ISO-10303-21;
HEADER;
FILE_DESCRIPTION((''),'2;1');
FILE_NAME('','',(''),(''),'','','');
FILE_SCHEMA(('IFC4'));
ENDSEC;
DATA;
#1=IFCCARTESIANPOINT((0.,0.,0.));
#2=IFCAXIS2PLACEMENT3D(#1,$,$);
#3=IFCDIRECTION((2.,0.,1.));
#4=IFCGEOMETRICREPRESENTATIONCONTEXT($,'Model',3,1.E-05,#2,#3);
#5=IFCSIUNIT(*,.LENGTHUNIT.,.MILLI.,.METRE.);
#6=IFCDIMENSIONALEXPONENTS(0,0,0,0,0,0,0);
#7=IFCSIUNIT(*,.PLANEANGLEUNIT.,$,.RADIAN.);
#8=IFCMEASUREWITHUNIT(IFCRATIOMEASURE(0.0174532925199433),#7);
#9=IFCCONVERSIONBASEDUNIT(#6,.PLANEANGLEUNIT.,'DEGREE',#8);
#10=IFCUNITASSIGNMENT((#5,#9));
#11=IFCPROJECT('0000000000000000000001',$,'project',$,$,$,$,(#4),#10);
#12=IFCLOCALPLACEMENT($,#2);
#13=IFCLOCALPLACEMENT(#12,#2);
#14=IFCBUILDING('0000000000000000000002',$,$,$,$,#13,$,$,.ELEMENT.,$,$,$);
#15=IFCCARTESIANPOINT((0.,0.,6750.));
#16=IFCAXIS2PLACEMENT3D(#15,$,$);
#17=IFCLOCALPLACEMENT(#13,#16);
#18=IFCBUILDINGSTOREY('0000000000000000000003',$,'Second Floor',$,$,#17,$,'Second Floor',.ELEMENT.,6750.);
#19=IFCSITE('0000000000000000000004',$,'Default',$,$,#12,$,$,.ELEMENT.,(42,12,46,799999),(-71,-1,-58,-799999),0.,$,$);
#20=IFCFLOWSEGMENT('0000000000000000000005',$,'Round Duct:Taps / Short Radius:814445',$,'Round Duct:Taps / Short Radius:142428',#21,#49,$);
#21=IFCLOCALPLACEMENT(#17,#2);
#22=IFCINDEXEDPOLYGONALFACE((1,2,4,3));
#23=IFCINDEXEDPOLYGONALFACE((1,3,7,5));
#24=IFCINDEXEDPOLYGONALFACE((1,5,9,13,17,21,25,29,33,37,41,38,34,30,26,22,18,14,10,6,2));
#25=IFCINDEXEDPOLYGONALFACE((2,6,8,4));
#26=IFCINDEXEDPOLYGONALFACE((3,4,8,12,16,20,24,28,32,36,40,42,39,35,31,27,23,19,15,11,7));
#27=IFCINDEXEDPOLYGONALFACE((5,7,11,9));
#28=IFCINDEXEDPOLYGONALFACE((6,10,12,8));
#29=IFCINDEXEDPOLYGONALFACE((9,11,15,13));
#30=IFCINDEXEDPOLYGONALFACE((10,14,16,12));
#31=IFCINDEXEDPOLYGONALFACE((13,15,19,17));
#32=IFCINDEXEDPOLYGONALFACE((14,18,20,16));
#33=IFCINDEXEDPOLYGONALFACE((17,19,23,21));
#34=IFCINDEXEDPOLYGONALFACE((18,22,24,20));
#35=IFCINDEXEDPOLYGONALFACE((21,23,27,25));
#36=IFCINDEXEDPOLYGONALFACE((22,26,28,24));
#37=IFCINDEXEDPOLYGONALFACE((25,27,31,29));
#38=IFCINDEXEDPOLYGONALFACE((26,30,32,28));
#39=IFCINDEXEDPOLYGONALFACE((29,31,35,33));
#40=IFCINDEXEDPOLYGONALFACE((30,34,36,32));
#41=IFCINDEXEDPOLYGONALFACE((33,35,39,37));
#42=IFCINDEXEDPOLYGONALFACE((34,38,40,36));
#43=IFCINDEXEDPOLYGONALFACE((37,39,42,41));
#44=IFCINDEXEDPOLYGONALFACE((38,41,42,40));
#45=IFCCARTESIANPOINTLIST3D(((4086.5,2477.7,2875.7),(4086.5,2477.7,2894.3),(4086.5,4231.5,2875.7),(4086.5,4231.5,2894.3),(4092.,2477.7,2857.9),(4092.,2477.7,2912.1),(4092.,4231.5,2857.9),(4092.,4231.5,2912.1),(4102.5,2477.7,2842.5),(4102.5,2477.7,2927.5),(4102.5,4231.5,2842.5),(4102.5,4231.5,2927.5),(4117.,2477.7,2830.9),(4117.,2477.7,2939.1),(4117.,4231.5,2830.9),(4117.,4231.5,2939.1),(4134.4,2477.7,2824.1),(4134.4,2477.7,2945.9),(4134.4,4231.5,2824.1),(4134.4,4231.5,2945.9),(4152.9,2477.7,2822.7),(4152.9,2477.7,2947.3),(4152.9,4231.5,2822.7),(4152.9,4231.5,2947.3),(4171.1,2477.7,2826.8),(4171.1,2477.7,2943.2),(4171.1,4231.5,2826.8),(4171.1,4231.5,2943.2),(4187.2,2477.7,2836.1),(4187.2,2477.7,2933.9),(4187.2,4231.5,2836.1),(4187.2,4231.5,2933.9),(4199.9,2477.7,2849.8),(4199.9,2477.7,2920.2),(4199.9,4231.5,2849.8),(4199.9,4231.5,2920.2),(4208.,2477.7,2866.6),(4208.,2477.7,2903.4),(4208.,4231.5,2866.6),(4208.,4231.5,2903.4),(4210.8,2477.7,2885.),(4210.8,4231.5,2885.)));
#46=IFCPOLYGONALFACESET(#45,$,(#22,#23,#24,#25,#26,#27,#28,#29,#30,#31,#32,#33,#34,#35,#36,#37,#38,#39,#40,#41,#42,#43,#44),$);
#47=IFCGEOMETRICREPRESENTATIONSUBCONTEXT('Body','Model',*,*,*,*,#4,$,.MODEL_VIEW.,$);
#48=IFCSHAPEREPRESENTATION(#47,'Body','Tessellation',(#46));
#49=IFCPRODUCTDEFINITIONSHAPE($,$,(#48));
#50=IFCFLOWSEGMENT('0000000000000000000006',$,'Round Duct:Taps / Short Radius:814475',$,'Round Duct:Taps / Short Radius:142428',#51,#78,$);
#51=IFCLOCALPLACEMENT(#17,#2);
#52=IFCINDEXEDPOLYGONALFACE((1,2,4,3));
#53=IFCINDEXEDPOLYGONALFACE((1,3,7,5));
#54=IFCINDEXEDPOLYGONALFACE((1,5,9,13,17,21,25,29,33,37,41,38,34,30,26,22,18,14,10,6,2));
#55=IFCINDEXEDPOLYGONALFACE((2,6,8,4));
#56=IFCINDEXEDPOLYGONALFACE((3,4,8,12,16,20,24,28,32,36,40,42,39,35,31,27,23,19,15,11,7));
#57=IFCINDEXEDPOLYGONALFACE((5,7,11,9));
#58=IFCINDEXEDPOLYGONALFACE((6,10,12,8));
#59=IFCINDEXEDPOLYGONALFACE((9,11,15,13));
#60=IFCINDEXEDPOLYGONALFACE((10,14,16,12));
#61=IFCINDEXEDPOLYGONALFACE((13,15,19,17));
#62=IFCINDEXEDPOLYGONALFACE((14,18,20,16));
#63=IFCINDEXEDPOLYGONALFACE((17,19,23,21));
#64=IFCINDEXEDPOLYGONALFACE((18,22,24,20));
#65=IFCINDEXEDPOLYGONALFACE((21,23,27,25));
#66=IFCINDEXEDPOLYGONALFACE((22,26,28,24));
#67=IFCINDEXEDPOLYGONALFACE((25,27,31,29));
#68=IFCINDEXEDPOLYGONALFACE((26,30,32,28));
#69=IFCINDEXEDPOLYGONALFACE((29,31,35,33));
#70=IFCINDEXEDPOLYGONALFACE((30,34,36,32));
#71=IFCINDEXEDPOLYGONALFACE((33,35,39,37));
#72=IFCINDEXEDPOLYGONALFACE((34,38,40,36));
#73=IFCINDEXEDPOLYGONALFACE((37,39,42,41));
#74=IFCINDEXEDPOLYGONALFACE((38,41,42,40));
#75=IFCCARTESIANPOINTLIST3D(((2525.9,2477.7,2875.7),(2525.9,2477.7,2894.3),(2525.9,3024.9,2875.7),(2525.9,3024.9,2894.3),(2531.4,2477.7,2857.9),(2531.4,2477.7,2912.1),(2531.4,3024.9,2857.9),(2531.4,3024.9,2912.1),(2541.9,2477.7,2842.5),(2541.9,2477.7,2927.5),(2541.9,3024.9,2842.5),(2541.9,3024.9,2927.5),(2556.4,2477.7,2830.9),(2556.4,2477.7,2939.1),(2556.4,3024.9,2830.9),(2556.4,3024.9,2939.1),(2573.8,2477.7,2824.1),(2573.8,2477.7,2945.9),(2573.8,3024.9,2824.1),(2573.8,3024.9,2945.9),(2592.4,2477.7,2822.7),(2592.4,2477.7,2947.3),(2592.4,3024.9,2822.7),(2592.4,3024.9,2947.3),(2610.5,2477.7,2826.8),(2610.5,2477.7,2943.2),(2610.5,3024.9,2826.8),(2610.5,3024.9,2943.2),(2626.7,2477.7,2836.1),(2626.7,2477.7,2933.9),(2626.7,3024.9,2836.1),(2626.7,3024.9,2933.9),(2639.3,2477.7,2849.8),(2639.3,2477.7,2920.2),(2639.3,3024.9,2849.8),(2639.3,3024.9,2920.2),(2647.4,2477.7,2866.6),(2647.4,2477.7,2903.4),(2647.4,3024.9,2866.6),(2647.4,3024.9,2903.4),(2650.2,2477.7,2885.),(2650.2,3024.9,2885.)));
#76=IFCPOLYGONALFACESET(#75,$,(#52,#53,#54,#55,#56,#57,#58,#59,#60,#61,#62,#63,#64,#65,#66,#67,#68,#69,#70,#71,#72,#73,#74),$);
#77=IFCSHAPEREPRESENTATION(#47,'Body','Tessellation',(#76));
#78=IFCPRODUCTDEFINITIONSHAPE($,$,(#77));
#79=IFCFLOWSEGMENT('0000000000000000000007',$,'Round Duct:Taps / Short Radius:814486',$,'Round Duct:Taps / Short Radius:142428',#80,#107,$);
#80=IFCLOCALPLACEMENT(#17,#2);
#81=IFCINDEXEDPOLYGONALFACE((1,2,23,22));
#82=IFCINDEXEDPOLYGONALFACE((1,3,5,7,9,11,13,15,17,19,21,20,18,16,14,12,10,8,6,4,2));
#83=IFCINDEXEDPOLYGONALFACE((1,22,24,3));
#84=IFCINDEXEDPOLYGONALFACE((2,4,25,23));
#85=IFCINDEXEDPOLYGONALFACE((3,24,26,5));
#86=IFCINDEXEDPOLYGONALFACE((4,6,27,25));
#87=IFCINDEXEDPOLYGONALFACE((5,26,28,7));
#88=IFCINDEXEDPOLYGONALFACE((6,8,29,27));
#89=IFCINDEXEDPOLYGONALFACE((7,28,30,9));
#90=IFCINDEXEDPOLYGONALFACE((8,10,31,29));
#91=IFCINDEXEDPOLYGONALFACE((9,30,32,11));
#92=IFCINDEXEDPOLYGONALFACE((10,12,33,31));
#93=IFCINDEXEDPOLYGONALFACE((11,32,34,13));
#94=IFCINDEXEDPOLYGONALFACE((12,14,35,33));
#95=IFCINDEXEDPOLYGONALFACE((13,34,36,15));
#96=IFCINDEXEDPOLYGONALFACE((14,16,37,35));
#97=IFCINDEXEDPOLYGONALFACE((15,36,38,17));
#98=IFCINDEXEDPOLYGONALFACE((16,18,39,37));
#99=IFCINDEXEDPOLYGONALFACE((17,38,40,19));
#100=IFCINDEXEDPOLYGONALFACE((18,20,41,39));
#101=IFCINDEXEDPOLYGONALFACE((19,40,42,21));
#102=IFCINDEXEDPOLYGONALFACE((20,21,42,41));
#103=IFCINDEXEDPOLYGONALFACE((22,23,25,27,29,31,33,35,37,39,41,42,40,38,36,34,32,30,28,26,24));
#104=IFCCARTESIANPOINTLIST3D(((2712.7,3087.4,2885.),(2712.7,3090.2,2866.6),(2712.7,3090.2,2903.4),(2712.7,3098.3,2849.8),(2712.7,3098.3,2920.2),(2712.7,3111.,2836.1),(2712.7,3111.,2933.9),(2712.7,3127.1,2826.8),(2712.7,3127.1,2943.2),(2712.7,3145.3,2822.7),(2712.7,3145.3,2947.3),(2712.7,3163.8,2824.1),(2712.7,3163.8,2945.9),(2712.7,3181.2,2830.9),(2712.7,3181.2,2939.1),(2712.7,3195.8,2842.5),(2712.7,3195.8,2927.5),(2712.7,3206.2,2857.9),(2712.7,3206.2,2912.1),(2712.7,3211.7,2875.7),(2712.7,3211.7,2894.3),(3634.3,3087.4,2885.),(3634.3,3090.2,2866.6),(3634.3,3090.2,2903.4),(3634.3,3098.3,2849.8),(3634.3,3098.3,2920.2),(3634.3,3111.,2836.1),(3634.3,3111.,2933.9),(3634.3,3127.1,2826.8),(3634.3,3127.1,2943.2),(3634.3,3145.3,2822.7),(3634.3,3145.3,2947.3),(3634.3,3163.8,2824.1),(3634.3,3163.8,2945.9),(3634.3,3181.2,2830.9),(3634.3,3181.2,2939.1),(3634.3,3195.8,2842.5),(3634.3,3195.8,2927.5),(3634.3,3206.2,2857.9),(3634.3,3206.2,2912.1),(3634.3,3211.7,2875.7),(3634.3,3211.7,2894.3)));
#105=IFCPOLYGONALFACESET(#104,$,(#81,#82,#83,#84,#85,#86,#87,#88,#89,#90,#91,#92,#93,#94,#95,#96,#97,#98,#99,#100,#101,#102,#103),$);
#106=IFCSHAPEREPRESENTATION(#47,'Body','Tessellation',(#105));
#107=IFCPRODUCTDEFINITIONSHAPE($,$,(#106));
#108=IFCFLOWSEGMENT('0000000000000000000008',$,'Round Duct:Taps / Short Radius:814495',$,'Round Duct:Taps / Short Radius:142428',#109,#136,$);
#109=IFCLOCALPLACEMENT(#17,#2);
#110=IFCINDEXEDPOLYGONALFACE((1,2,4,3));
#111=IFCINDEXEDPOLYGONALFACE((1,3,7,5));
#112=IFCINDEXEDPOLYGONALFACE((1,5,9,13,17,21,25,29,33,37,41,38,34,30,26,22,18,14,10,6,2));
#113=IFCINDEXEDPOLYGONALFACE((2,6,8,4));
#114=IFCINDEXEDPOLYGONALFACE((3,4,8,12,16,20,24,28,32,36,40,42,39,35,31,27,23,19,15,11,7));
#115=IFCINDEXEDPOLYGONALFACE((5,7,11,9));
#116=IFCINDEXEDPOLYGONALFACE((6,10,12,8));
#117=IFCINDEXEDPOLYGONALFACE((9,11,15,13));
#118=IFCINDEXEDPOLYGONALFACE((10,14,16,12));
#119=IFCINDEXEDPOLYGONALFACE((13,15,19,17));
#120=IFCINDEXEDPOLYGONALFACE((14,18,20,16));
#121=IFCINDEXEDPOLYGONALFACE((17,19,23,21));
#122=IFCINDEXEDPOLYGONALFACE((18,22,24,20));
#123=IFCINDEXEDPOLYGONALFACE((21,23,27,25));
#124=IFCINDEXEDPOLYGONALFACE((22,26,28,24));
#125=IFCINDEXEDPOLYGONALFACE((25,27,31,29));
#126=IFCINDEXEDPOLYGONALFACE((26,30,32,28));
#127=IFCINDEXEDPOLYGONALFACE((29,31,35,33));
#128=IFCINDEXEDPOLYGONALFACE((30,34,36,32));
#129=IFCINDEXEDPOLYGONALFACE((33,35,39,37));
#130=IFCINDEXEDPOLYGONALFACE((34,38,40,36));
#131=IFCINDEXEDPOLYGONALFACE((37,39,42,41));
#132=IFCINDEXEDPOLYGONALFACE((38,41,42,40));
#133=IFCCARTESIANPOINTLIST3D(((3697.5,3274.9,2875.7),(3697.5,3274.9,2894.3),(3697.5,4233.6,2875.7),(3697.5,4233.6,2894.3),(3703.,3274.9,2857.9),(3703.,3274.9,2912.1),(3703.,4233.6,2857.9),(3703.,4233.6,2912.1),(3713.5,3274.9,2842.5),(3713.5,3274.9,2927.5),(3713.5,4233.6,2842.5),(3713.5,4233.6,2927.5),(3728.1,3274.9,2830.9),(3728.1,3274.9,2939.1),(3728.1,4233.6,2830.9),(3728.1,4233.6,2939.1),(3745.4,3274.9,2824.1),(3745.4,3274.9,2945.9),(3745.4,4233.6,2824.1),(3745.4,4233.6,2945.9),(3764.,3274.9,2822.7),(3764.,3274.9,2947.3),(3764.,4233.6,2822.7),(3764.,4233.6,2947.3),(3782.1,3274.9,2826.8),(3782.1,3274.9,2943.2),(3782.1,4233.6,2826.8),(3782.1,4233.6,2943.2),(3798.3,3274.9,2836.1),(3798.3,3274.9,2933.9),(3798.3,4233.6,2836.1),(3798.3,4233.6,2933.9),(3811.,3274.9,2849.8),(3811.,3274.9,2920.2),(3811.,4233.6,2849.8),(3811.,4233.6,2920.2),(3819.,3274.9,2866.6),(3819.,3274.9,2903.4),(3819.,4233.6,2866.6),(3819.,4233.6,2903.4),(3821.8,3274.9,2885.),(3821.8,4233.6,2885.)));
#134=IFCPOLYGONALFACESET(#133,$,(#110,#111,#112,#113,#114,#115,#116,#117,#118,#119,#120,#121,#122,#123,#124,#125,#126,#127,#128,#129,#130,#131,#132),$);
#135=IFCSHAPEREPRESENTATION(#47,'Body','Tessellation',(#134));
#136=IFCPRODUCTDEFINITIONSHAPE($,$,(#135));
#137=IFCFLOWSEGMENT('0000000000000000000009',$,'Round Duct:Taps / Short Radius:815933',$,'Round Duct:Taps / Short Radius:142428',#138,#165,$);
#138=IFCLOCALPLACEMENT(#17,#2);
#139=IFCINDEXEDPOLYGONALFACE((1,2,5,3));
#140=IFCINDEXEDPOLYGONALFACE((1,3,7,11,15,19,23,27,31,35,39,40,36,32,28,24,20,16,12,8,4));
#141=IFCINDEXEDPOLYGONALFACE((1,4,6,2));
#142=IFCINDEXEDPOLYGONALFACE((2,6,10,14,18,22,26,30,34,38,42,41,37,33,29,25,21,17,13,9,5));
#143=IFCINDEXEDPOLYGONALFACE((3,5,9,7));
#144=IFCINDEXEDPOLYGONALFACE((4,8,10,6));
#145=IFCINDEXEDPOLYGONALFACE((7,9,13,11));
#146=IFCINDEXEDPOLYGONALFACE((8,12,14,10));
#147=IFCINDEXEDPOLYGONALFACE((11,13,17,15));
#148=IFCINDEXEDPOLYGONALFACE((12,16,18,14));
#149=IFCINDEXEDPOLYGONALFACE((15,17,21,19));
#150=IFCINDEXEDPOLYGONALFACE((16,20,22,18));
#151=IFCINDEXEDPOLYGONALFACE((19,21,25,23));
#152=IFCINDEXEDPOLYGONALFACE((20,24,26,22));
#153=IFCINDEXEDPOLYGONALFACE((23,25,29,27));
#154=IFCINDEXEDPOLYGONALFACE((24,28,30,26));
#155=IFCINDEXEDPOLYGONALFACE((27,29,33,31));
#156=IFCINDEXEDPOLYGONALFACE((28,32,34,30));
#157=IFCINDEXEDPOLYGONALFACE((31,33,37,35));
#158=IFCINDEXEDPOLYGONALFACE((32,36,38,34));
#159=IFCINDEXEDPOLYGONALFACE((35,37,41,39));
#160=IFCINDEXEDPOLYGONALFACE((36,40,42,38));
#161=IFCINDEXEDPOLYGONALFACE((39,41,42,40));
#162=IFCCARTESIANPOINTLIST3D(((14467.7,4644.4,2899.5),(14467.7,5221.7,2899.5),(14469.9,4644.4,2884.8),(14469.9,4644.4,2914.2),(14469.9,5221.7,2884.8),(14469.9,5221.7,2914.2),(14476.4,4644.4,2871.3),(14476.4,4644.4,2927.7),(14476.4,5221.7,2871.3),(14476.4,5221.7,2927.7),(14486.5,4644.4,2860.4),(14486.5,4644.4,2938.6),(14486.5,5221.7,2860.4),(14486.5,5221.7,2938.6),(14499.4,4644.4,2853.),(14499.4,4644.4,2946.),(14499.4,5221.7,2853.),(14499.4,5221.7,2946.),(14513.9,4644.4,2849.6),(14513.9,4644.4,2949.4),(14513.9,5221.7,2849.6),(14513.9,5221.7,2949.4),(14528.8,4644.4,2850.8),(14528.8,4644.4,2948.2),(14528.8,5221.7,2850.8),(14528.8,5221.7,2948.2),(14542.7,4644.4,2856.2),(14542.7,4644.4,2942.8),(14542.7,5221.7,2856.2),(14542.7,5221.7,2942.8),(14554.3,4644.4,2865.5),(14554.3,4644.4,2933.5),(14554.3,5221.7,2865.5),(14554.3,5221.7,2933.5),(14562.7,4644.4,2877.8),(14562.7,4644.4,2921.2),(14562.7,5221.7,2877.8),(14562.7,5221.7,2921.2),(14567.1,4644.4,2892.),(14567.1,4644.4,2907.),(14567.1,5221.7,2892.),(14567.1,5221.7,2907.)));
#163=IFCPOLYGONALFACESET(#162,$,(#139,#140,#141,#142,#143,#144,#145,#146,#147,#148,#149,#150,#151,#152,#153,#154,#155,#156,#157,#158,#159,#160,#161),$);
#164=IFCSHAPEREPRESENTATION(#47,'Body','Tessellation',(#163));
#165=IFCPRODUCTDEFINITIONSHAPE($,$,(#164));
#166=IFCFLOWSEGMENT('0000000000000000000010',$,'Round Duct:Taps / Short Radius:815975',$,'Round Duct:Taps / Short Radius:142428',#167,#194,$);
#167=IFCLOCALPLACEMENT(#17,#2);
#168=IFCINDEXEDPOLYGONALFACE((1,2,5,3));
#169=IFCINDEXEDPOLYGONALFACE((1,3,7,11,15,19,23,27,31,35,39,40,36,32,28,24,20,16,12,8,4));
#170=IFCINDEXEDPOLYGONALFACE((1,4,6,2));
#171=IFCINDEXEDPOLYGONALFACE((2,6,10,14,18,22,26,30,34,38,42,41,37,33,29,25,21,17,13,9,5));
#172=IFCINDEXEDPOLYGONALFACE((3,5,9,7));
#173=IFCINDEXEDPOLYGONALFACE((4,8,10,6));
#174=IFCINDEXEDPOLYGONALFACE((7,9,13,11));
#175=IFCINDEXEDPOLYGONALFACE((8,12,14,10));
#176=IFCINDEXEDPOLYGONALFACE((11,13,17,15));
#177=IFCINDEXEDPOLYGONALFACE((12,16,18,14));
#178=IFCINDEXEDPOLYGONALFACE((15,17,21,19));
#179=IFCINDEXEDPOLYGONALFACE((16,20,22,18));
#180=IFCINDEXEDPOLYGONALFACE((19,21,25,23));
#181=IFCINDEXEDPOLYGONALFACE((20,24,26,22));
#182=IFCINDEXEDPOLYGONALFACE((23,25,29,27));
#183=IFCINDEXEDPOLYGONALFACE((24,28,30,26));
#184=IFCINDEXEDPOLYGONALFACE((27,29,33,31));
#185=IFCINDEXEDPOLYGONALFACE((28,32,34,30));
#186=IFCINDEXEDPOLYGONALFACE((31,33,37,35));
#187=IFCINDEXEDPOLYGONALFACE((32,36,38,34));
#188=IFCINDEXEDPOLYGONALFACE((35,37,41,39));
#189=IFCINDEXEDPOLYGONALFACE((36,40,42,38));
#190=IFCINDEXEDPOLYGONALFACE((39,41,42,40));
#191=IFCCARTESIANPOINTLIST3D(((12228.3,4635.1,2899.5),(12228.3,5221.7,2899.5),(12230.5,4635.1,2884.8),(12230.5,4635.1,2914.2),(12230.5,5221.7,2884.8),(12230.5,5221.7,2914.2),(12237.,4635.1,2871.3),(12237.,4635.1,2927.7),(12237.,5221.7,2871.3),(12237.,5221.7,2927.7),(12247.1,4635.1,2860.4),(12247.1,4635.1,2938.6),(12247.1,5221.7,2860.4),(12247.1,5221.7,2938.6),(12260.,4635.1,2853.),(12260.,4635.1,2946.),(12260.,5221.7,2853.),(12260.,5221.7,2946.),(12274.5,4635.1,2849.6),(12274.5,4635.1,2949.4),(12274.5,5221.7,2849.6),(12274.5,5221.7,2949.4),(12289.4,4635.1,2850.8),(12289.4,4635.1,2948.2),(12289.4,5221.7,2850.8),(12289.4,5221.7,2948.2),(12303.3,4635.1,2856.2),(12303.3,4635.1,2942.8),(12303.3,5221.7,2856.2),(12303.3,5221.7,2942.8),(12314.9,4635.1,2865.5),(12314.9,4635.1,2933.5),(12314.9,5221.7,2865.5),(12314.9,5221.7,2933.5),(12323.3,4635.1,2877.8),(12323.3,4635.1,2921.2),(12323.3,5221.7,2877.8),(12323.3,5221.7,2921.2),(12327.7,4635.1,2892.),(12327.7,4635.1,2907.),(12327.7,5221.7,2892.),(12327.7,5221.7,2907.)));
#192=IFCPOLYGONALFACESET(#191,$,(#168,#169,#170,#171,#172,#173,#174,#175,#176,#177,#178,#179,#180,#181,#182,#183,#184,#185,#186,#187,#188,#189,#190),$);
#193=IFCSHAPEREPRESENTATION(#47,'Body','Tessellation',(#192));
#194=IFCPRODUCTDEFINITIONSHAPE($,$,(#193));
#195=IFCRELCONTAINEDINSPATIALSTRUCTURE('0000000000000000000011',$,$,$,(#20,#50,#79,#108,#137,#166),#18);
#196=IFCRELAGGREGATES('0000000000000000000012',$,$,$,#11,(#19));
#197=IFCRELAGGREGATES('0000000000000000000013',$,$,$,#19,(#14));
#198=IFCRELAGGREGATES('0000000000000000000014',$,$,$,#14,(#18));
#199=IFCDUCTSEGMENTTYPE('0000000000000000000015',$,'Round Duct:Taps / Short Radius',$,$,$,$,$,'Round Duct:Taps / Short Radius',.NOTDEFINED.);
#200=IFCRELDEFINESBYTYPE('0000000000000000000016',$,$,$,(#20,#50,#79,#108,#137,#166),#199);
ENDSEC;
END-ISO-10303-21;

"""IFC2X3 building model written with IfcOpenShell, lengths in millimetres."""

from ifc_helpers import new_model, entity, si_unit, converted_unit, direction, frame, frame_2d, origin, origin_2d_with_axis, place, context, subcontext, project, spatial, circle, extrude, type_object, element, save


model = new_model("IFC2X3")

# Units and contexts
model_context = context("Model", 3, precision=1e-05, world=origin(), true_north=direction((2.0, 0.0, 1.0)))
body_context = subcontext(model_context, "Body", "Model", "MODEL_VIEW")
ifc_project = project(units=[si_unit("LENGTHUNIT", "METRE", prefix="MILLI"), converted_unit("PLANEANGLEUNIT", "DEGREE", entity("IfcRatioMeasure", 0.0174532925199433), si_unit("PLANEANGLEUNIT", "RADIAN"), dimensions=[0, 0, 0, 0, 0, 0, 0])], contexts=[model_context])

# Site, building, storey
site_placement = place(None, origin())
site = spatial("IfcSite", under=ifc_project, at=site_placement, Name="Default", CompositionType="ELEMENT", RefLatitude=(42, 12, 46, 799999), RefLongitude=(-71, -1, -58, -799999), RefElevation=0.0)
building_placement = place(site_placement, origin())
building = spatial("IfcBuilding", under=site, at=building_placement, CompositionType="ELEMENT")
storey_placement = place(building_placement, frame((0.0, 0.0, 6750.0)))
storey = spatial("IfcBuildingStorey", under=building, at=storey_placement, Name="Second Floor", LongName="Second Floor", CompositionType="ELEMENT", Elevation=6750.0)

# Flow segments
duct_segment_type = type_object("IfcDuctSegmentType", Name="Round Duct:Taps / Short Radius", ElementType="Round Duct:Taps / Short Radius", PredefinedType="NOTDEFINED")
flow_segment_1_placement = place(storey_placement, origin())
element("IfcFlowSegment", 1, at=flow_segment_1_placement, inside=storey, type_object=duct_segment_type, Name="Round Duct:Taps / Short Radius:814445", ObjectType="Round Duct:Taps / Short Radius:142428", context=body_context, shape_type="SweptSolid", body=[
    extrude(circle(Radius=62.5, at=frame_2d((0.0, 0.0), x_axis=(1.0, 0.0))), frame((4148.3, 2477.7, 2885.0), z_axis=(0.0, 1.0, 0.0), x_axis=(1.0, 0.0, 0.0)), (0.0, 0.0, 1.0), 1753.8),
])
flow_segment_2_placement = place(storey_placement, origin())
element("IfcFlowSegment", 2, at=flow_segment_2_placement, inside=storey, type_object=duct_segment_type, Name="Round Duct:Taps / Short Radius:814475", ObjectType="Round Duct:Taps / Short Radius:142428", context=body_context, shape_type="SweptSolid", body=[
    extrude(circle(Radius=62.5, at=origin_2d_with_axis()), frame((2587.7, 2477.7, 2885.0), z_axis=(0.0, 1.0, 0.0), x_axis=(1.0, 0.0, 0.0)), (0.0, 0.0, 1.0), 547.2),
])
flow_segment_3_placement = place(storey_placement, origin())
element("IfcFlowSegment", 3, at=flow_segment_3_placement, inside=storey, type_object=duct_segment_type, Name="Round Duct:Taps / Short Radius:814486", ObjectType="Round Duct:Taps / Short Radius:142428", context=body_context, shape_type="SweptSolid", body=[
    extrude(circle(Radius=62.5, at=frame_2d((0.0, 0.0), x_axis=(1.0, 0.0))), frame((2712.7, 3149.9, 2885.0), z_axis=(1.0, 0.0, 0.0), x_axis=(0.0, -1.0, 0.0)), (0.0, 0.0, 1.0), 921.6),
])
flow_segment_4_placement = place(storey_placement, origin())
element("IfcFlowSegment", 4, at=flow_segment_4_placement, inside=storey, type_object=duct_segment_type, Name="Round Duct:Taps / Short Radius:814495", ObjectType="Round Duct:Taps / Short Radius:142428", context=body_context, shape_type="SweptSolid", body=[
    extrude(circle(Radius=62.5, at=frame_2d((0.0, 0.0), x_axis=(1.0, 0.0))), frame((3759.3, 3274.9, 2885.0), z_axis=(0.0, 1.0, 0.0), x_axis=(1.0, 0.0, 0.0)), (0.0, 0.0, 1.0), 958.6),
])
flow_segment_5_placement = place(storey_placement, origin())
element("IfcFlowSegment", 5, at=flow_segment_5_placement, inside=storey, type_object=duct_segment_type, Name="Round Duct:Taps / Short Radius:815933", ObjectType="Round Duct:Taps / Short Radius:142428", context=body_context, shape_type="SweptSolid", body=[
    extrude(circle(Radius=50.0, at=frame_2d((0.0, 0.0), x_axis=(1.0, 0.0))), frame((14517.7, 4644.4, 2899.5), z_axis=(0.0, 1.0, 0.0), x_axis=(-1.0, 0.0, 0.0)), (0.0, 0.0, 1.0), 577.3),
])
flow_segment_6_placement = place(storey_placement, origin())
element("IfcFlowSegment", 6, at=flow_segment_6_placement, inside=storey, type_object=duct_segment_type, Name="Round Duct:Taps / Short Radius:815975", ObjectType="Round Duct:Taps / Short Radius:142428", context=body_context, shape_type="SweptSolid", body=[
    extrude(circle(Radius=50.0, at=frame_2d((0.0, 0.0), x_axis=(1.0, 0.0))), frame((12278.3, 4635.1, 2899.5), z_axis=(0.0, 1.0, 0.0), x_axis=(-1.0, 0.0, 0.0)), (0.0, 0.0, 1.0), 586.6),
])

save(model, "model.ifc")
